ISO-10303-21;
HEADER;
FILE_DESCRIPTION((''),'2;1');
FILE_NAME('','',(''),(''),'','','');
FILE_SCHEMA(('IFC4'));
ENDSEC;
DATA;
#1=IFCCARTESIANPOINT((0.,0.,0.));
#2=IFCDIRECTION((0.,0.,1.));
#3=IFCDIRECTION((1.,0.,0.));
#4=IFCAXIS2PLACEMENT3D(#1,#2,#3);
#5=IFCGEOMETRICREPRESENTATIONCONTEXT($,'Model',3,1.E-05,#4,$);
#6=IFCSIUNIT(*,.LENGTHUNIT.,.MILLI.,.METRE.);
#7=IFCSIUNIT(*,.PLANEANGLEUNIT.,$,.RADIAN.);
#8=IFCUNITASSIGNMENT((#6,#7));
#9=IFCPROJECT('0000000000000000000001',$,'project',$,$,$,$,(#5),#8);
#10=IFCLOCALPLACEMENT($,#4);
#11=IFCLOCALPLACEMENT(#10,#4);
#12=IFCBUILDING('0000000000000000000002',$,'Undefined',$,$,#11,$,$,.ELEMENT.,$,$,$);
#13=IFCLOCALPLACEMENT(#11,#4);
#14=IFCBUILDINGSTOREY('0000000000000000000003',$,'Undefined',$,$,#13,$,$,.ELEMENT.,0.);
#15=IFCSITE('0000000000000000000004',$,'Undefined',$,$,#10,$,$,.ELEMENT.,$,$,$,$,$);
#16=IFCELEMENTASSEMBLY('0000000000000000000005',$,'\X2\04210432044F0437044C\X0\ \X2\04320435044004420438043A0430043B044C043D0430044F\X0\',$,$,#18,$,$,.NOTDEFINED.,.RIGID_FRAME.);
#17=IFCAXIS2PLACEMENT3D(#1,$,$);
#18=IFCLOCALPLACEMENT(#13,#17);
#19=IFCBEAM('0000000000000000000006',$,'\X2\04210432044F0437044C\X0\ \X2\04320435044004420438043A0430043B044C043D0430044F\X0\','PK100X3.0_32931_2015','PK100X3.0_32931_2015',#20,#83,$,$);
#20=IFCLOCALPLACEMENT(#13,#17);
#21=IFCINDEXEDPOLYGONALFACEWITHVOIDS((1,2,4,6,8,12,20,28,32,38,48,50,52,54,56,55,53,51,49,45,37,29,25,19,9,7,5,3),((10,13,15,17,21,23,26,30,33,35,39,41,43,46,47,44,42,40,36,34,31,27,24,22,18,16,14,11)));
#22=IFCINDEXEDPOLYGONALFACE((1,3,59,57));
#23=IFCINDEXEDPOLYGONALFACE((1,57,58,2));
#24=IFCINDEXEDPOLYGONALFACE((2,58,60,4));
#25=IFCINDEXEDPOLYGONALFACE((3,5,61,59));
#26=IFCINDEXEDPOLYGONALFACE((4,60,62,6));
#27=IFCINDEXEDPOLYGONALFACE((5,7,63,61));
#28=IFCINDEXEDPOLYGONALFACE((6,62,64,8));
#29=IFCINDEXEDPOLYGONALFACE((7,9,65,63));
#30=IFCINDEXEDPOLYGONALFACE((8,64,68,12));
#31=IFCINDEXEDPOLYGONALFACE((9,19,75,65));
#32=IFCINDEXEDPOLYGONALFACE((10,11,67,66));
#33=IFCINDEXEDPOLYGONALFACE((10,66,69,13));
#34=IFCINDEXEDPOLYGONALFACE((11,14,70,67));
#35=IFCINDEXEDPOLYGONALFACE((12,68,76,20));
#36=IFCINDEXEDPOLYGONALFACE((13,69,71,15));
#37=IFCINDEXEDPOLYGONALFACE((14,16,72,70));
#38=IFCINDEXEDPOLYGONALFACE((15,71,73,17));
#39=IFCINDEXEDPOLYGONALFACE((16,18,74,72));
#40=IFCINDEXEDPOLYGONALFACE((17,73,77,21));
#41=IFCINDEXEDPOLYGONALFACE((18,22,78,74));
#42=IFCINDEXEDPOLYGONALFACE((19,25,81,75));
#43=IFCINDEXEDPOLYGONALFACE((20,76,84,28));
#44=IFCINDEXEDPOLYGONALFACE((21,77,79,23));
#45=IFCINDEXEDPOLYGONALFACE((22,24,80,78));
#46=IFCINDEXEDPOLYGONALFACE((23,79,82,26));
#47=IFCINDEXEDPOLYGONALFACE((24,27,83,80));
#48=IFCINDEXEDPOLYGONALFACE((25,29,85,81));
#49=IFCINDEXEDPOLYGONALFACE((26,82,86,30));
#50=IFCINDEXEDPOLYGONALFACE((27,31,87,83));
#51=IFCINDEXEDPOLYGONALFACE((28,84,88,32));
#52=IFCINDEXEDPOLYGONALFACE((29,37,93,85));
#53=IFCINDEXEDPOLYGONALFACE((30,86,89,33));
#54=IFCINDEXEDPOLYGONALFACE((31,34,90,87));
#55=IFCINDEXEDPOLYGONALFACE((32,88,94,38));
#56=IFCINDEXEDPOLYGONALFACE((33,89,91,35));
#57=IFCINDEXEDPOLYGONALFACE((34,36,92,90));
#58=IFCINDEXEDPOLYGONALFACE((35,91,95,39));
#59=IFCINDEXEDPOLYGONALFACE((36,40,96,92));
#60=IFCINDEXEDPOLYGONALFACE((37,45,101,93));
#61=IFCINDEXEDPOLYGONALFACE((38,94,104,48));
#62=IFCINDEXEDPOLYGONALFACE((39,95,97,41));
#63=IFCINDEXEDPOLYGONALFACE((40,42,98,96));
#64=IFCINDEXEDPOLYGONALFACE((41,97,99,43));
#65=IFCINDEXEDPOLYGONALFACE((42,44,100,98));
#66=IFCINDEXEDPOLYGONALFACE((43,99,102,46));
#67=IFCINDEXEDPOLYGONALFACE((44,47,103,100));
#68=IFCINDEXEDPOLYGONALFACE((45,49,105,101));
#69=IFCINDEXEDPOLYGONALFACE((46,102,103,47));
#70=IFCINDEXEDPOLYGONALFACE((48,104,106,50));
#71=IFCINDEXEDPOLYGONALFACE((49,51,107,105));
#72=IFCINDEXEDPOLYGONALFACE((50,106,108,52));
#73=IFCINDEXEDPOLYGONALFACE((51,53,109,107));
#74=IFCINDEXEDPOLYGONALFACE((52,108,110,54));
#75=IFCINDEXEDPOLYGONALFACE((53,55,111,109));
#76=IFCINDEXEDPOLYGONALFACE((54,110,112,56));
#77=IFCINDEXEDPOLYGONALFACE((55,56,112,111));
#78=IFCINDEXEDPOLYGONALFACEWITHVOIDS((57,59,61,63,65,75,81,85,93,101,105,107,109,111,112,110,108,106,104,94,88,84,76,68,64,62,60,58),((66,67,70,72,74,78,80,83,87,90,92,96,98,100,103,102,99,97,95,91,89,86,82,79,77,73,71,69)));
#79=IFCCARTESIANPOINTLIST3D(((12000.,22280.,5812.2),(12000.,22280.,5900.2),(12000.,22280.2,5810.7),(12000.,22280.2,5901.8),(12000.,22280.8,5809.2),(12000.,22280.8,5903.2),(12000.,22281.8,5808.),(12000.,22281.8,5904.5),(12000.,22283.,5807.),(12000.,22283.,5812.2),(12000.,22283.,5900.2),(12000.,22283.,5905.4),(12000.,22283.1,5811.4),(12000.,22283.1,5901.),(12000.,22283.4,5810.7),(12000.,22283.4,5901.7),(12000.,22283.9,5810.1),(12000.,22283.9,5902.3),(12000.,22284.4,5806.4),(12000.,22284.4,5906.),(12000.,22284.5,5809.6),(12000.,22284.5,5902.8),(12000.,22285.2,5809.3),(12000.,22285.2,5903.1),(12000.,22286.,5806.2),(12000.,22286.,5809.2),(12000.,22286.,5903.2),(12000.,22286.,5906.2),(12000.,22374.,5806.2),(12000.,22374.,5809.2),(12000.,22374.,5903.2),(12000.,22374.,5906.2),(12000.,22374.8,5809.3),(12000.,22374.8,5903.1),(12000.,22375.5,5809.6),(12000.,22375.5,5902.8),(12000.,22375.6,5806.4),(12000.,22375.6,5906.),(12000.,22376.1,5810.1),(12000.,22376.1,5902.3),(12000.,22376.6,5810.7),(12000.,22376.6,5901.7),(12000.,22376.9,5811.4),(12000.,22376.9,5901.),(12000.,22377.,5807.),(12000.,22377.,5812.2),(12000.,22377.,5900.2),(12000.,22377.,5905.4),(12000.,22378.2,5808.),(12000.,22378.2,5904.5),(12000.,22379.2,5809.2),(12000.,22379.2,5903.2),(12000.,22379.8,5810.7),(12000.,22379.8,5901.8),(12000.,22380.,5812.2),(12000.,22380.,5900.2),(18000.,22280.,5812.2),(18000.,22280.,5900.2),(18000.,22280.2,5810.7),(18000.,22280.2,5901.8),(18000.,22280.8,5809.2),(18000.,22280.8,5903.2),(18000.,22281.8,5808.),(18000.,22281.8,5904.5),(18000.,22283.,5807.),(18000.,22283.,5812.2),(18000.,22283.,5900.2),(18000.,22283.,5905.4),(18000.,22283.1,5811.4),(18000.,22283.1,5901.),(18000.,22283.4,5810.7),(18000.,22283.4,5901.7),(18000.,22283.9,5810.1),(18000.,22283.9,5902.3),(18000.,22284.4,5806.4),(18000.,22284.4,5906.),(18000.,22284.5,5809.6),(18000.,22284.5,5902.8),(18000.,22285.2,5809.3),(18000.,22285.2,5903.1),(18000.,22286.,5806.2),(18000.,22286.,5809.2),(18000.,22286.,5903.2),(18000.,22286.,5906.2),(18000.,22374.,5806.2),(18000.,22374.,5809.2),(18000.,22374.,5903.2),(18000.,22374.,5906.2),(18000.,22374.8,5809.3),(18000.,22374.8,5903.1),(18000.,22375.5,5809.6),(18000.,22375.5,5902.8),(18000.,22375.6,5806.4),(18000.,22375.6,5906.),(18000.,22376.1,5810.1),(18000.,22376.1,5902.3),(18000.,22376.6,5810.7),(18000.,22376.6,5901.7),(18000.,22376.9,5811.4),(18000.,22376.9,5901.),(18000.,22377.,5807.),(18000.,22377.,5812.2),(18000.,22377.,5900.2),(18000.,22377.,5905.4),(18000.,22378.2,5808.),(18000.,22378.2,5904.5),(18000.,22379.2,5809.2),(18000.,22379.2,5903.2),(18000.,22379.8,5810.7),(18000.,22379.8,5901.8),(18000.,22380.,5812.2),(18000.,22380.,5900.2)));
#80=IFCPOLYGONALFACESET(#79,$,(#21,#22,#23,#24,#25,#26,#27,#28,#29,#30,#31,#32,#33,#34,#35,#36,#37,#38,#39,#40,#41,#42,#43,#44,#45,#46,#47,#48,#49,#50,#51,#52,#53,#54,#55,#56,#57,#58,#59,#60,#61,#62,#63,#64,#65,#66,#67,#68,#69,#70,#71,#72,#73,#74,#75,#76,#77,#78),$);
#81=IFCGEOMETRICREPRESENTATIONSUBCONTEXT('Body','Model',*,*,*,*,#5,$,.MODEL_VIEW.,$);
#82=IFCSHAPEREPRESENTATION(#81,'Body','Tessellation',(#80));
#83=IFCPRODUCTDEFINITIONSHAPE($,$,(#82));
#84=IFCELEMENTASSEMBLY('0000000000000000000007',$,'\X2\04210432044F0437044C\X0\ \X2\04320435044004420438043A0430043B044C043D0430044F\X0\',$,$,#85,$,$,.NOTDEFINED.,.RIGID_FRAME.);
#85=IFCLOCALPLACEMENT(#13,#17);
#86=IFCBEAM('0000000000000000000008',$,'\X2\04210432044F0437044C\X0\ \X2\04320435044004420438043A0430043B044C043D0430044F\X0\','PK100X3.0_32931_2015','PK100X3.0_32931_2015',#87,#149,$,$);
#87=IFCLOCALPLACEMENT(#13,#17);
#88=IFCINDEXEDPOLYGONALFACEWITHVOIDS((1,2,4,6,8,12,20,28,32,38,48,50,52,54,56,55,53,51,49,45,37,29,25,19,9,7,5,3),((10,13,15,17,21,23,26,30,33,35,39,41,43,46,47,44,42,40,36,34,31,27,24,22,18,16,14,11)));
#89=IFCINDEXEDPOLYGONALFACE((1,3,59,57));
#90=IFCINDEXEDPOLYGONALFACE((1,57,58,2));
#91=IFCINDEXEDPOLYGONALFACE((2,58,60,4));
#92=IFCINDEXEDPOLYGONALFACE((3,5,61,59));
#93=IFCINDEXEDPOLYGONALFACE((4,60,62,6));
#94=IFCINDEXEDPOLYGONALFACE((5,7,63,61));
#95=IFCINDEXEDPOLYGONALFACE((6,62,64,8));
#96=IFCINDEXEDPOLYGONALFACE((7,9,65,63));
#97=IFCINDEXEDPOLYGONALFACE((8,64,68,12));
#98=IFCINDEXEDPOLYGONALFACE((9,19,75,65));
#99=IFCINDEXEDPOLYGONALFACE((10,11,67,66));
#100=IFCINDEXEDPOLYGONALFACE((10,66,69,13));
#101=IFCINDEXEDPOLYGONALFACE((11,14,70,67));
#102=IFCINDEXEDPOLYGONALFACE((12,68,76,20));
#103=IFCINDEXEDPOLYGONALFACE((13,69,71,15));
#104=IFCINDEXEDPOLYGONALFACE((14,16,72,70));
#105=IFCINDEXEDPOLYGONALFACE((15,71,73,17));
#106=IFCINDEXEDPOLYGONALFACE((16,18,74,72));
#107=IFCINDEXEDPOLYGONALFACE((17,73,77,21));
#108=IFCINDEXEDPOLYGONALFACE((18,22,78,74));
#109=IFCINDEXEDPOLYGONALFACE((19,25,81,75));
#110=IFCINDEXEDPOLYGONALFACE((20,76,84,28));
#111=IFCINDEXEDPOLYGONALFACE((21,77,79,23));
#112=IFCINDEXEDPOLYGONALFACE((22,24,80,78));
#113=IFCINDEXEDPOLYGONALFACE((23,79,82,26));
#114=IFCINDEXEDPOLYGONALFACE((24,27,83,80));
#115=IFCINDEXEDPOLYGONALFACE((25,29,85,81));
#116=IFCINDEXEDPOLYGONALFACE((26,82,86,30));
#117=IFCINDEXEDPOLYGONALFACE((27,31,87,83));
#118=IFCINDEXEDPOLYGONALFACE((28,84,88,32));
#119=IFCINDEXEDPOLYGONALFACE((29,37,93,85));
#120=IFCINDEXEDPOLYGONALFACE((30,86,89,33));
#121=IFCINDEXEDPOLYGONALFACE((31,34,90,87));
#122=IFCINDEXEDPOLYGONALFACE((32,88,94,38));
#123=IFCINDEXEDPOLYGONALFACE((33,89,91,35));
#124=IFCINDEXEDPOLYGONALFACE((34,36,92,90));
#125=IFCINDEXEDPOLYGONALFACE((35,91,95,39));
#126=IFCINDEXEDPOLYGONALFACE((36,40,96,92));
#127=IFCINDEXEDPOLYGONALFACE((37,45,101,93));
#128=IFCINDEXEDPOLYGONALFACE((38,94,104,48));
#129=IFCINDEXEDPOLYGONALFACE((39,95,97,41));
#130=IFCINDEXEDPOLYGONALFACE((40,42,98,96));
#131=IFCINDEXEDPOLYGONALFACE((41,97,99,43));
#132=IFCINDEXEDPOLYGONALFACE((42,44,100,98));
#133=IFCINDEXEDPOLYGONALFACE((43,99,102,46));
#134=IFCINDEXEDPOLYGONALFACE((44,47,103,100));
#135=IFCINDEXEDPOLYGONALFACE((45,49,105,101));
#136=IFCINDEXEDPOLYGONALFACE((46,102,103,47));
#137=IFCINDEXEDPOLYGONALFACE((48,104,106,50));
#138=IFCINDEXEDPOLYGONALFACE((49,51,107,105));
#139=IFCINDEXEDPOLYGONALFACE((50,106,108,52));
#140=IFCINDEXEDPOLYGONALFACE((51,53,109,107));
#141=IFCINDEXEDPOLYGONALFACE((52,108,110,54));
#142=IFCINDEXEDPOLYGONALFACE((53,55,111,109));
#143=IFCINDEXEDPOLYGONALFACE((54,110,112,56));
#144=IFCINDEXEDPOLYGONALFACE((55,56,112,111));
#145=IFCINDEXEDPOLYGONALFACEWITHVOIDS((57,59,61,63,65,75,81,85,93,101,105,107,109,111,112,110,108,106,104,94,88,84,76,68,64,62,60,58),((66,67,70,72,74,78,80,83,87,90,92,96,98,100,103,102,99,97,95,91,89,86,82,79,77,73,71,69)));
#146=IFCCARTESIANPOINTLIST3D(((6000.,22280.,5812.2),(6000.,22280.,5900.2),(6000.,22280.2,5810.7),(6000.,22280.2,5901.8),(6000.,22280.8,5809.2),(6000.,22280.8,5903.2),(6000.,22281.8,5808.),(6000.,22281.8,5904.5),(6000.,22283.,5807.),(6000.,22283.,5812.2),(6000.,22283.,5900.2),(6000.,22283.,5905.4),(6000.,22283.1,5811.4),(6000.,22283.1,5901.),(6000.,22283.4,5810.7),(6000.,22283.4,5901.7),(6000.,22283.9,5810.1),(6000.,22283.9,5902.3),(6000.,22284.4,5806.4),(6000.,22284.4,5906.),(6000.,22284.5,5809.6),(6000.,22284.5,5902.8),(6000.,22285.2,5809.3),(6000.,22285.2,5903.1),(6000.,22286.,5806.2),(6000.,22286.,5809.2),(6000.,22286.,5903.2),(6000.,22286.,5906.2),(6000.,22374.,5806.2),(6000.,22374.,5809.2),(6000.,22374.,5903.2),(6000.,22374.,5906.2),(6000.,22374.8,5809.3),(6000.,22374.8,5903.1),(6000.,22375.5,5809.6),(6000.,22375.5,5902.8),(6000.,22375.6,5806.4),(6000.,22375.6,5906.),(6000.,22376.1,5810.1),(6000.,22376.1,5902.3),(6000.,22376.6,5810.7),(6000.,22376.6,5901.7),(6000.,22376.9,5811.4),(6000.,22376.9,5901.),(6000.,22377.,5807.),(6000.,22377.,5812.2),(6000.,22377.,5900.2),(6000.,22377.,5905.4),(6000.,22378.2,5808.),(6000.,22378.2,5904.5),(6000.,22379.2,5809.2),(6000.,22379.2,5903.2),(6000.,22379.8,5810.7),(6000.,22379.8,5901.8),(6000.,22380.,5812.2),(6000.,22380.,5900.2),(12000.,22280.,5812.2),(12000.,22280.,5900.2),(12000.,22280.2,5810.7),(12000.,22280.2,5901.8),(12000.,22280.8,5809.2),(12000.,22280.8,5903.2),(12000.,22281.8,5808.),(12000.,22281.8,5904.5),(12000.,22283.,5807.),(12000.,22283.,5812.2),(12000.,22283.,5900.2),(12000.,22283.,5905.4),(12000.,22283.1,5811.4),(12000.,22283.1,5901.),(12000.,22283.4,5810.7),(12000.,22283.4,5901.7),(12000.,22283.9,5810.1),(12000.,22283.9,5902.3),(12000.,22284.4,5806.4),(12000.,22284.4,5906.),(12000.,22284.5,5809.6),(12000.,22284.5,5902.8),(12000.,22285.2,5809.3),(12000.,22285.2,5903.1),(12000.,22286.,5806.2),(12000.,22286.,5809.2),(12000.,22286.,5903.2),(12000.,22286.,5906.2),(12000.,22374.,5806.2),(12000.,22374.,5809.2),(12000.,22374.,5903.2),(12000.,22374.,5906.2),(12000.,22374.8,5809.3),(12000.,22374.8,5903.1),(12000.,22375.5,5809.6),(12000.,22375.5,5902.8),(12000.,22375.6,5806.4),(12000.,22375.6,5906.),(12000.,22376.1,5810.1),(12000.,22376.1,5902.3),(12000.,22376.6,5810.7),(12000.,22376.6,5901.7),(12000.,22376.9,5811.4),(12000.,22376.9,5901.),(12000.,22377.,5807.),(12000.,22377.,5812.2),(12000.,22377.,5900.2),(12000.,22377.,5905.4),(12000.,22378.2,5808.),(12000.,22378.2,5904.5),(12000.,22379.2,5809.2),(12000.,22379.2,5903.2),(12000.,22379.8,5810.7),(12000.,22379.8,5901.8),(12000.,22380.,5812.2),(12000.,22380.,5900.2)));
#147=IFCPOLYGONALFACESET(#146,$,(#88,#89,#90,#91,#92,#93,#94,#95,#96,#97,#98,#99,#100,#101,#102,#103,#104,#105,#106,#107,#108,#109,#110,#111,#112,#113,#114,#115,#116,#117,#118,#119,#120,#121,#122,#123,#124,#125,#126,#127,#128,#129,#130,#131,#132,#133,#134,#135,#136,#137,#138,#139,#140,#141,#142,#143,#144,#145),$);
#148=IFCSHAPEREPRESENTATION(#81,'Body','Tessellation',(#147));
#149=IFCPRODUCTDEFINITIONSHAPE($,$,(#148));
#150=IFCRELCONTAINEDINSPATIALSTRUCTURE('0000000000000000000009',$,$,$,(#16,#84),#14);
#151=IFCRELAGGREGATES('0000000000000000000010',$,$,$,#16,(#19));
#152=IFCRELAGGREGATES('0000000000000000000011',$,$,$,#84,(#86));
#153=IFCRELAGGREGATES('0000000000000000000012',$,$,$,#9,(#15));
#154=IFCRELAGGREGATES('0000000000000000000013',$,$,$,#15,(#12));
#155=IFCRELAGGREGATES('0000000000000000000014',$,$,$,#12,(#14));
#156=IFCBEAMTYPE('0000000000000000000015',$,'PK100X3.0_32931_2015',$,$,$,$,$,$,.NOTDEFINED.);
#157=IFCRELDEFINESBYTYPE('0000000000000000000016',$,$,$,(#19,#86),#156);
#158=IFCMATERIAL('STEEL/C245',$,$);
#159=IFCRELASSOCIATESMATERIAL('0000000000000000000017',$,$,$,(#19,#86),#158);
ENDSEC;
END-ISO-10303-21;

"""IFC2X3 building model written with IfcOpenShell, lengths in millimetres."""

from ifc_helpers import new_model, si_unit, frame, origin_with_axes, origin_2d_with_axis, place, context, subcontext, project, spatial, hollow_rectangle, extrude, material, type_object, element, aggregate, save


model = new_model("IFC2X3")

# Units and contexts
model_context = context("Model", 3, precision=1e-05, world=origin_with_axes())
body_context = subcontext(model_context, "Body", "Model", "MODEL_VIEW")
ifc_project = project(units=[si_unit("LENGTHUNIT", "METRE", prefix="MILLI"), si_unit("PLANEANGLEUNIT", "RADIAN")], contexts=[model_context])

# Site, building, storey
site_placement = place(None, origin_with_axes())
site = spatial("IfcSite", under=ifc_project, at=site_placement, Name="Undefined", CompositionType="ELEMENT")
building_placement = place(site_placement, origin_with_axes())
building = spatial("IfcBuilding", under=site, at=building_placement, Name="Undefined", CompositionType="ELEMENT")
storey_placement = place(building_placement, origin_with_axes())
storey = spatial("IfcBuildingStorey", under=building, at=storey_placement, Name="Undefined", CompositionType="ELEMENT", Elevation=0.0)

# Element assemblies, beams
assembly_1_placement = place(storey_placement, origin_with_axes())
assembly_1 = element("IfcElementAssembly", 1, at=assembly_1_placement, inside=storey, Name="Связь вертикальная", AssemblyPlace="NOTDEFINED", PredefinedType="RIGID_FRAME")
ifc_material_1 = material(Name="STEEL/C245")
beam_type_1 = type_object("IfcBeamType", Name="PK100X3.0_32931_2015", PredefinedType="NOTDEFINED")
beam_1_placement = place(assembly_1_placement, frame((12000.0, 22330.0, 5856.2), z_axis=(0.0, 0.0, 1.0), x_axis=(1.0, 0.0, 0.0)))
beam_1 = element("IfcBeam", 2, at=beam_1_placement, type_object=beam_type_1, material=ifc_material_1, Name="Связь вертикальная", Description="PK100X3.0_32931_2015", ObjectType="PK100X3.0_32931_2015", context=body_context, shape_type="SweptSolid", body=[
    extrude(hollow_rectangle(XDim=100.0, YDim=100.0, WallThickness=3.0, InnerFilletRadius=3.0, OuterFilletRadius=6.0, at=origin_2d_with_axis()), frame((6000.0, 0.0, 0.0), z_axis=(-1.0, 0.0, 0.0), x_axis=(0.0, -1.0, 0.0)), (0.0, 0.0, 1.0), 6000.0),
])
aggregate(assembly_1, [beam_1])
assembly_2_placement = place(storey_placement, origin_with_axes())
assembly_2 = element("IfcElementAssembly", 3, at=assembly_2_placement, inside=storey, Name="Связь вертикальная", AssemblyPlace="NOTDEFINED", PredefinedType="RIGID_FRAME")
beam_2_placement = place(assembly_2_placement, frame((6000.0, 22330.0, 5856.2), z_axis=(0.0, 0.0, 1.0), x_axis=(1.0, 0.0, 0.0)))
beam_2 = element("IfcBeam", 4, at=beam_2_placement, type_object=beam_type_1, material=ifc_material_1, Name="Связь вертикальная", Description="PK100X3.0_32931_2015", ObjectType="PK100X3.0_32931_2015", context=body_context, shape_type="SweptSolid", body=[
    extrude(hollow_rectangle(XDim=100.0, YDim=100.0, WallThickness=3.0, InnerFilletRadius=3.0, OuterFilletRadius=6.0, at=origin_2d_with_axis()), frame((6000.0, 0.0, 0.0), z_axis=(-1.0, 0.0, 0.0), x_axis=(0.0, -1.0, 0.0)), (0.0, 0.0, 1.0), 6000.0),
])
aggregate(assembly_2, [beam_2])

save(model, "model.ifc")
